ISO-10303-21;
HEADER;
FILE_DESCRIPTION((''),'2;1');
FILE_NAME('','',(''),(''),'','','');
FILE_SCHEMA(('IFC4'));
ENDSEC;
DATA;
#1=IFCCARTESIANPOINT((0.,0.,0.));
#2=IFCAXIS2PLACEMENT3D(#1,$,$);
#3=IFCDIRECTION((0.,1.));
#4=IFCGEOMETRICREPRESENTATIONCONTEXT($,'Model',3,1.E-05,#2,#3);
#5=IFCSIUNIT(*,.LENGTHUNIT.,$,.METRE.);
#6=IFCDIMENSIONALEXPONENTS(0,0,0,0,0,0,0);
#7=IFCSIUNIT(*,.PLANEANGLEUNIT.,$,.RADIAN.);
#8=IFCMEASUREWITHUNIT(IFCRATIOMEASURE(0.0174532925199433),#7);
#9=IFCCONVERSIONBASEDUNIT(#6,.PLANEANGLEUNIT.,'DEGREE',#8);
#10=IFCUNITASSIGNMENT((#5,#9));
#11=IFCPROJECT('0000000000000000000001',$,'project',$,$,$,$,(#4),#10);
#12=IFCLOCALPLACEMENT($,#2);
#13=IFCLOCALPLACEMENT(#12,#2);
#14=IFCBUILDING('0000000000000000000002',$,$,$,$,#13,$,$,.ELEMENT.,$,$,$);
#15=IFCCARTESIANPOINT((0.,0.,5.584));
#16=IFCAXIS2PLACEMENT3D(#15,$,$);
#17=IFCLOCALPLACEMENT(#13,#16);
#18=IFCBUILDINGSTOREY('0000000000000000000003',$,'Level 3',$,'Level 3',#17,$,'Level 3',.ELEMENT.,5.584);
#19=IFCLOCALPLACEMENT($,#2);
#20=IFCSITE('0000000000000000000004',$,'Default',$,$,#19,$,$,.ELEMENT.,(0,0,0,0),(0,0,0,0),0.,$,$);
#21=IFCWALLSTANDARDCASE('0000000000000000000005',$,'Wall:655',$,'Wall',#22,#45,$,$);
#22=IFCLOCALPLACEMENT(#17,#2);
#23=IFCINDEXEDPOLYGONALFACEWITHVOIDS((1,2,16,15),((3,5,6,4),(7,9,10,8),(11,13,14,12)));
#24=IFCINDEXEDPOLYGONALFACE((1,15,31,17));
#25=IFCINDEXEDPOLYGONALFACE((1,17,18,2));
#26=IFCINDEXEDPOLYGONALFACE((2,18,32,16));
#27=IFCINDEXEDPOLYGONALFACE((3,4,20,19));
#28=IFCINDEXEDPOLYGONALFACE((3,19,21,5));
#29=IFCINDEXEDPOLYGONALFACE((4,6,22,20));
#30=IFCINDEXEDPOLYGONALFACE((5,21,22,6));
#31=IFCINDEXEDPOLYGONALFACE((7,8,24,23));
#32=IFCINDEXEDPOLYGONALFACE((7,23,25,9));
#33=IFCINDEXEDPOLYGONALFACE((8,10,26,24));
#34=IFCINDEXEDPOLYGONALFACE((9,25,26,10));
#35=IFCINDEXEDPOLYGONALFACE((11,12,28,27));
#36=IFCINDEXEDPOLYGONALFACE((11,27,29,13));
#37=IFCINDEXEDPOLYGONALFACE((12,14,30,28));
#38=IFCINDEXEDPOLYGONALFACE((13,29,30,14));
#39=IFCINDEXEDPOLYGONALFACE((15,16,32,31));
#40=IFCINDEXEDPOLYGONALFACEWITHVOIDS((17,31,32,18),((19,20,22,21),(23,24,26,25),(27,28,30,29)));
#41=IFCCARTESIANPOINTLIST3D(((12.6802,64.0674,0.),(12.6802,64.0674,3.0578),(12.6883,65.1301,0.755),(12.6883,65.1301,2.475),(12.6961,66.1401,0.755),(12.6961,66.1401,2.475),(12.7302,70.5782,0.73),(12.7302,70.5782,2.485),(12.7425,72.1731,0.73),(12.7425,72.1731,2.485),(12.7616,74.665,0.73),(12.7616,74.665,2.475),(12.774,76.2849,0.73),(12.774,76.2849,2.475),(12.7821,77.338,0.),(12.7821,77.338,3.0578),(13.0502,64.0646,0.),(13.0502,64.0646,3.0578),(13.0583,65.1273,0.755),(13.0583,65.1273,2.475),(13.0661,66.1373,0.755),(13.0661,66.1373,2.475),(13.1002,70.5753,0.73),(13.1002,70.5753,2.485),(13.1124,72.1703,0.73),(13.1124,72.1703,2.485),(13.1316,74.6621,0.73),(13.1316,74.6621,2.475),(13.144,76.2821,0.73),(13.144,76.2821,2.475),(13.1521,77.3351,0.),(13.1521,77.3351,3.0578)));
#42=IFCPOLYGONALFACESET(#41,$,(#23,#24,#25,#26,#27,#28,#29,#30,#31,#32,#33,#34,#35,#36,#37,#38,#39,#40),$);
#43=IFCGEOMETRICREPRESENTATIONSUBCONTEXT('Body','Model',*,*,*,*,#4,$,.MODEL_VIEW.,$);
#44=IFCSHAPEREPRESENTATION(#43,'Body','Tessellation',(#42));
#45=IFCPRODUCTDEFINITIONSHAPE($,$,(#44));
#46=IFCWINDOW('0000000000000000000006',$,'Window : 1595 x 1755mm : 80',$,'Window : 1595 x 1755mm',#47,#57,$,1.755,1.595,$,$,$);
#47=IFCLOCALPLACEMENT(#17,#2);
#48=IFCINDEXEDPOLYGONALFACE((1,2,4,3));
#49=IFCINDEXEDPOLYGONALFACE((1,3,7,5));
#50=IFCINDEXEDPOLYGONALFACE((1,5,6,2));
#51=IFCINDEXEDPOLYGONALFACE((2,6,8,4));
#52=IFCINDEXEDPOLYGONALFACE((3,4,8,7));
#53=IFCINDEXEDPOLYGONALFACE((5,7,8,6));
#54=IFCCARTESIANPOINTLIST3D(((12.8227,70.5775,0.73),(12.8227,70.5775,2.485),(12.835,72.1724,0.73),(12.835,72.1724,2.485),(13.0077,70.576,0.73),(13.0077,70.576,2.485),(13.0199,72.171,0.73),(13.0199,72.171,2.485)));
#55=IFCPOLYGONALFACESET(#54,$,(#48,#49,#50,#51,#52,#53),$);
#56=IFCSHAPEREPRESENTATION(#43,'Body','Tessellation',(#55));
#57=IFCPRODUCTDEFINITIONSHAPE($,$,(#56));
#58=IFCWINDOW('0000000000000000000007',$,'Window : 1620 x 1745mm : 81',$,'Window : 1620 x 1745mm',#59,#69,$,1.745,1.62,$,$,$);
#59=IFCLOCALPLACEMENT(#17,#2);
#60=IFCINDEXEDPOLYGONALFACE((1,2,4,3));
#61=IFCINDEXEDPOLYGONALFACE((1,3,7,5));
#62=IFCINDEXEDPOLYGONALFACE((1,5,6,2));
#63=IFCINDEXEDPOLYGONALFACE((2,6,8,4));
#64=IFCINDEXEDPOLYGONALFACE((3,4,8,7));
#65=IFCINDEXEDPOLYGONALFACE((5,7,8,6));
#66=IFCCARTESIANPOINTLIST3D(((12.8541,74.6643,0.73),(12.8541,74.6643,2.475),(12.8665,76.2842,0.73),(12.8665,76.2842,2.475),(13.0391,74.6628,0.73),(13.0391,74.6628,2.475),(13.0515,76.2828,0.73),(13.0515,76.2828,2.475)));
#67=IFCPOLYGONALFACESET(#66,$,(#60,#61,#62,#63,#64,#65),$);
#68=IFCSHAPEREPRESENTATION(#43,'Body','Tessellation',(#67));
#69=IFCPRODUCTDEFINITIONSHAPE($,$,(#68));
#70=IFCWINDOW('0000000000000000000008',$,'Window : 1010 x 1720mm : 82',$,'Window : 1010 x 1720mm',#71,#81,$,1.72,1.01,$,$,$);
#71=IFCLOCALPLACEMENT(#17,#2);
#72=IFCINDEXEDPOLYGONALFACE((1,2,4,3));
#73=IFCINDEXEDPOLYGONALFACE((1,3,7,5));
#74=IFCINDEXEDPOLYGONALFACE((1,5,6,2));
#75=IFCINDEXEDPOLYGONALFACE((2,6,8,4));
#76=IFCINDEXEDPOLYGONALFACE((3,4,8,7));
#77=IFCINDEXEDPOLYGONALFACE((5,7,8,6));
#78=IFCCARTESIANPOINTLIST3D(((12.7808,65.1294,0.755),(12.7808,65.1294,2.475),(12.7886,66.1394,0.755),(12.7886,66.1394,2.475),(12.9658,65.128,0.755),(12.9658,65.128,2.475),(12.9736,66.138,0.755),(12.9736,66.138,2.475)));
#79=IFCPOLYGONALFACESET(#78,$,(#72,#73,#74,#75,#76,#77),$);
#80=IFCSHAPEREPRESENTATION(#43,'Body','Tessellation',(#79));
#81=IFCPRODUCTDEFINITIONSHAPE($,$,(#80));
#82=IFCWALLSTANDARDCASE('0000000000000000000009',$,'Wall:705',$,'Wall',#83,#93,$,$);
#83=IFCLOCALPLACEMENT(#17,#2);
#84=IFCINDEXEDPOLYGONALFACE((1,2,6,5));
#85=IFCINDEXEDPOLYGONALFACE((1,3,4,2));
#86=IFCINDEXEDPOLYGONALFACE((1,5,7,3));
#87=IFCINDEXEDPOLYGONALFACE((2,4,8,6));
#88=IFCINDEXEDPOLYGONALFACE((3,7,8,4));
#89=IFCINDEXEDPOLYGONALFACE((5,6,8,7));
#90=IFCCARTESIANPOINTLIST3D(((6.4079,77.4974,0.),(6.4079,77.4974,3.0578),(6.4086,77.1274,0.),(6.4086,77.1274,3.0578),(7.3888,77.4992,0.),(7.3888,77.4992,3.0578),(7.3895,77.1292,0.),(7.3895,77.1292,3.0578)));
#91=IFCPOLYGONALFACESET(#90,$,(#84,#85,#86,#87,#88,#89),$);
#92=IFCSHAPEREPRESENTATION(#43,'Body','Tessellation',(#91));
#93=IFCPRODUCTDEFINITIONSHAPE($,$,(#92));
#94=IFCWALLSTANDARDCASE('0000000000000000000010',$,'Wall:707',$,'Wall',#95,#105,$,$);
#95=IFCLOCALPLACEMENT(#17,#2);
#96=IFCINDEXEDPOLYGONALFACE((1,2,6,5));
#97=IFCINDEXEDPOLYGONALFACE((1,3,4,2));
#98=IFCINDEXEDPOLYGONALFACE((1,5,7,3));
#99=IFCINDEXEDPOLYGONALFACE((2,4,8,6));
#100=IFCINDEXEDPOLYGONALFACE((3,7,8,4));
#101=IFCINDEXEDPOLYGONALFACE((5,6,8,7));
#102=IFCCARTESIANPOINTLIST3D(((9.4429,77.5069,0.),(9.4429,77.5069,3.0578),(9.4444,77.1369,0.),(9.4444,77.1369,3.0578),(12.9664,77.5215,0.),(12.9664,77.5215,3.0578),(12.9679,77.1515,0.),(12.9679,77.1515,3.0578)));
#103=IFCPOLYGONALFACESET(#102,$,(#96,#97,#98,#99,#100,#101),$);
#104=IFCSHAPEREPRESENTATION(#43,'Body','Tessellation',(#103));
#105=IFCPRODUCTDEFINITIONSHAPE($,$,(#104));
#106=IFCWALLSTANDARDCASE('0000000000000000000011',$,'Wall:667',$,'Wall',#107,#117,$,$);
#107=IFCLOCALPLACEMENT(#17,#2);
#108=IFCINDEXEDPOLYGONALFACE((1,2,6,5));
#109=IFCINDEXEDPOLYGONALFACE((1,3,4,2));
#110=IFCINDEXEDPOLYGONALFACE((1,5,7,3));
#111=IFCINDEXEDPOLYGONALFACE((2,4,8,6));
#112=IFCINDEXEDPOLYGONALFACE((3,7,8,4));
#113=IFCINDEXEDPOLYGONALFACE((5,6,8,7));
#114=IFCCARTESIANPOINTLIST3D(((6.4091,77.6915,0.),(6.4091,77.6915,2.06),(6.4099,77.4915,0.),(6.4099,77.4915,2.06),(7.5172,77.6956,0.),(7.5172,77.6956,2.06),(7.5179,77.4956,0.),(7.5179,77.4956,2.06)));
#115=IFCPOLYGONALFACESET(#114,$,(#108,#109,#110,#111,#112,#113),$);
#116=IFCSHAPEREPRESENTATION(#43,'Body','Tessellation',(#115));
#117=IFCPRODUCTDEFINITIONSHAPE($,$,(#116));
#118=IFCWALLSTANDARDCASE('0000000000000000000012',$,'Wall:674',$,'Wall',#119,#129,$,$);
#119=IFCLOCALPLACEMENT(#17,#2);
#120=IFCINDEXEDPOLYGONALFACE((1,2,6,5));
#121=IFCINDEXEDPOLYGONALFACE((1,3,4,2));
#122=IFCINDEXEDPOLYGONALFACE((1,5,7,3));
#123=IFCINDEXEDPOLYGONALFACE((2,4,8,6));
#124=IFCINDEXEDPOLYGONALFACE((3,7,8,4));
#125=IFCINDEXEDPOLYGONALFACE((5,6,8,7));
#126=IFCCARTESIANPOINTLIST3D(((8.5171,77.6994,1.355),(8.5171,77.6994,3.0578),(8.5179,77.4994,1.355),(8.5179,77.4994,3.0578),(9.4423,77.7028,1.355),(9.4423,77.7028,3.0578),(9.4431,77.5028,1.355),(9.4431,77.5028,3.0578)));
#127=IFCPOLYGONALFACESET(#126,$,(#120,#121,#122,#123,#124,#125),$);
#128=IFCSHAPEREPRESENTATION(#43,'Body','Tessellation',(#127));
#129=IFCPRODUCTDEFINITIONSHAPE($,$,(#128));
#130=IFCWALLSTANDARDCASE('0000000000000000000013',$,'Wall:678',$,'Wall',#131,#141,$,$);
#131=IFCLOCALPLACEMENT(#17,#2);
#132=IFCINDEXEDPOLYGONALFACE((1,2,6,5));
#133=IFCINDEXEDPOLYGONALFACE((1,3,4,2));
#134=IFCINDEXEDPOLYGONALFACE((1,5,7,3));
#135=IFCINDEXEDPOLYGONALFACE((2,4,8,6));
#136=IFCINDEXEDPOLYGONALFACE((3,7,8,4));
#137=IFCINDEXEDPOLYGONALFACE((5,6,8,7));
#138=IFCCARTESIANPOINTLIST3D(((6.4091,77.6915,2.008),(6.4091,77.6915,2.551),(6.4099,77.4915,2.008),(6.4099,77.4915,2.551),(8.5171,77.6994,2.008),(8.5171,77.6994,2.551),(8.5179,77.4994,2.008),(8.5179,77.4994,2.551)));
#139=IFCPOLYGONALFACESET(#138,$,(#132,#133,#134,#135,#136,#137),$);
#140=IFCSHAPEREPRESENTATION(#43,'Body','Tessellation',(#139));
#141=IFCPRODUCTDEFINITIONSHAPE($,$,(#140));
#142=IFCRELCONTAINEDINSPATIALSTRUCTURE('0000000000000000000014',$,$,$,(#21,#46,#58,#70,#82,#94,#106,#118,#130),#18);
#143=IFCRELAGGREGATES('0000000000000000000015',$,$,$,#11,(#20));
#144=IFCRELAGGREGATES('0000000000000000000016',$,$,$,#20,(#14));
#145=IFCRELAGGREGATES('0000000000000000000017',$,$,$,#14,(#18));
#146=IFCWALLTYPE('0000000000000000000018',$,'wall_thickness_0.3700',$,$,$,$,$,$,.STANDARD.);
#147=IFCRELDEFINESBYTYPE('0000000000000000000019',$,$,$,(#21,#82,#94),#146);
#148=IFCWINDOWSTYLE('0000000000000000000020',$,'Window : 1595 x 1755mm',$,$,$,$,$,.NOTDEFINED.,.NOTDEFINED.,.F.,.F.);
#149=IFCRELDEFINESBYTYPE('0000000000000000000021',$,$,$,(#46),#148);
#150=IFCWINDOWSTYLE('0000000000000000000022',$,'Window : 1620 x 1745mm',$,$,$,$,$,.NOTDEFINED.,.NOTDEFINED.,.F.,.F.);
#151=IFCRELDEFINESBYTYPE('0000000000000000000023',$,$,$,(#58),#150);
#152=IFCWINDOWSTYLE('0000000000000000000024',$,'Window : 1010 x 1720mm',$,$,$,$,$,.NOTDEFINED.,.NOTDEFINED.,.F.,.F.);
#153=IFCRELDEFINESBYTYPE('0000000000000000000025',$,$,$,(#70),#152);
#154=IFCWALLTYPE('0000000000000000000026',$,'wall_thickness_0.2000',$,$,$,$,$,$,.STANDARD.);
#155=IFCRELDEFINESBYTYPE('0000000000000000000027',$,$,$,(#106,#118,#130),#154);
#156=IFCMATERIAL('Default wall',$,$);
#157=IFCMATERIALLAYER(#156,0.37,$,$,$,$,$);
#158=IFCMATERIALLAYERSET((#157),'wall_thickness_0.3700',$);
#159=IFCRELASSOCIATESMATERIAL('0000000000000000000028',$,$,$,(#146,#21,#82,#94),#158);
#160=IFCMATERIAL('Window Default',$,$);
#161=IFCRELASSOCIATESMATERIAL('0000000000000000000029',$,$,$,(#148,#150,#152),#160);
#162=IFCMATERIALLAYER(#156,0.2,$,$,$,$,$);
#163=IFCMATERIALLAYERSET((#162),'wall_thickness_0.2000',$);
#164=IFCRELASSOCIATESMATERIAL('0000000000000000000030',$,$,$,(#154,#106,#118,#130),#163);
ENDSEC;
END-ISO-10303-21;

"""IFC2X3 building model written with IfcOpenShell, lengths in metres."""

from ifc_helpers import new_model, entity, si_unit, converted_unit, direction, frame, frame_2d, origin, origin_2d_with_axis, place, context, subcontext, project, spatial, polyline, rectangle, outline, extrude, source, transform, mapped, material, layer, layer_set, layer_usage, type_object, type_shapes, element, fill, save


model = new_model("IFC2X3")

# Units and contexts
model_context = context("Model", 3, precision=1e-05, world=origin(), true_north=direction((0.0, 1.0)))
body_context = subcontext(model_context, "Body", "Model", "MODEL_VIEW")
ifc_project = project(units=[si_unit("LENGTHUNIT", "METRE"), converted_unit("PLANEANGLEUNIT", "DEGREE", entity("IfcRatioMeasure", 0.0174532925199433), si_unit("PLANEANGLEUNIT", "RADIAN"), dimensions=[0, 0, 0, 0, 0, 0, 0])], contexts=[model_context])

# Site, building, storey
site_placement = place(None, origin())
site = spatial("IfcSite", under=ifc_project, at=site_placement, Name="Default", CompositionType="ELEMENT", RefLatitude=(0, 0, 0, 0), RefLongitude=(0, 0, 0, 0), RefElevation=0.0)
placement_1 = place(None, origin())
building_placement = place(placement_1, origin())
building = spatial("IfcBuilding", under=site, at=building_placement, CompositionType="ELEMENT")
storey_placement = place(building_placement, frame((0.0, 0.0, 5.584)))
storey = spatial("IfcBuildingStorey", under=building, at=storey_placement, Name="Level 3", ObjectType="Level 3", LongName="Level 3", CompositionType="ELEMENT", Elevation=5.584)

# Wall, openings, windows
ifc_material_1 = material(Name="Default wall")
ifc_layer_1 = layer(ifc_material_1, 0.37)
ifc_layer_set_1 = layer_set([ifc_layer_1], Name="wall_thickness_0.3700")
ifc_layer_usage_1 = layer_usage(ifc_layer_set_1, "AXIS2", "POSITIVE", -0.185)
wall_type_1 = type_object("IfcWallType", Name="wall_thickness_0.3700", PredefinedType="STANDARD", material=ifc_layer_set_1)
wall_1_placement = place(storey_placement, frame((12.9671, 77.3365, 0.0), z_axis=(0.0, 0.0, 1.0), x_axis=(-0.007684, -0.99997, 0.0)))
wall_1 = element("IfcWallStandardCase", 1, at=wall_1_placement, inside=storey, type_object=wall_type_1, material=ifc_layer_usage_1, Name="Wall:655", ObjectType="Wall", context=body_context, shape_type="SweptSolid", body=[
    extrude(outline(polyline([(13.2709, -0.185), (13.2709, 0.185), (0.0, 0.185), (0.0, -0.185), (13.2709, -0.185)])), origin(), (0.0, 0.0, 1.0), 3.0578),
])
opening_1_placement = place(wall_1_placement, frame((5.165, -0.185, 0.73)))
opening_1 = element("IfcOpeningElement", 2, at=opening_1_placement, cuts=wall_1, ObjectType="Opening", context=body_context, shape_type="SweptSolid", body=[
    extrude(rectangle(XDim=1.595, YDim=1.755, at=frame_2d((0.8775, 0.7975), x_axis=(0.0, 1.0))), frame((0.0, 0.0, 0.0), z_axis=(0.0, 1.0, 0.0), x_axis=(0.0, 0.0, 1.0)), (0.0, 0.0, 1.0), 0.37),
])
opening_2_placement = place(wall_1_placement, frame((1.0531, -0.185, 0.73)))
opening_2 = element("IfcOpeningElement", 3, at=opening_2_placement, cuts=wall_1, ObjectType="Opening", context=body_context, shape_type="SweptSolid", body=[
    extrude(rectangle(XDim=1.62, YDim=1.745, at=frame_2d((0.8725, 0.81), x_axis=(0.0, 1.0))), frame((0.0, 0.0, 0.0), z_axis=(0.0, 1.0, 0.0), x_axis=(0.0, 0.0, 1.0)), (0.0, 0.0, 1.0), 0.37),
])
opening_3_placement = place(wall_1_placement, frame((11.1982, -0.185, 0.755)))
opening_3 = element("IfcOpeningElement", 4, at=opening_3_placement, cuts=wall_1, ObjectType="Opening", context=body_context, shape_type="SweptSolid", body=[
    extrude(rectangle(XDim=1.01, YDim=1.72, at=frame_2d((0.86, 0.505), x_axis=(0.0, 1.0))), frame((0.0, 0.0, 0.0), z_axis=(0.0, 1.0, 0.0), x_axis=(0.0, 0.0, 1.0)), (0.0, 0.0, 1.0), 0.37),
])
ifc_material_2 = material(Name="Window Default")
window_style_1 = type_object("IfcWindowStyle", Name="Window : 1595 x 1755mm", ConstructionType="NOTDEFINED", OperationType="NOTDEFINED", ParameterTakesPrecedence=False, Sizeable=False, material=ifc_material_2)
shared_shape_1 = source(origin(), body_context, "Body", "SweptSolid", [
    extrude(rectangle(XDim=0.185, YDim=1.595, at=origin_2d_with_axis()), frame((0.7975, 0.185, 0.0), z_axis=(0.0, 0.0, 1.0), x_axis=(0.0, 1.0, 0.0)), (0.0, 0.0, 1.0), 1.755),
])
type_shapes(window_style_1, [shared_shape_1])
window_1_placement = place(opening_1_placement, origin())
window_1 = element("IfcWindow", 5, at=window_1_placement, inside=storey, type_object=window_style_1, Name="Window : 1595 x 1755mm : 80", ObjectType="Window : 1595 x 1755mm", OverallHeight=1.755, OverallWidth=1.595, context=body_context, shape_type="MappedRepresentation", body=[
    mapped(shared_shape_1, transform((0.0, 0.0, 0.0), scale=1.0)),
])
fill(opening_1, window_1)
window_style_2 = type_object("IfcWindowStyle", Name="Window : 1620 x 1745mm", ConstructionType="NOTDEFINED", OperationType="NOTDEFINED", ParameterTakesPrecedence=False, Sizeable=False, material=ifc_material_2)
shared_shape_2 = source(origin(), body_context, "Body", "SweptSolid", [
    extrude(rectangle(XDim=0.185, YDim=1.62, at=origin_2d_with_axis()), frame((0.81, 0.185, 0.0), z_axis=(0.0, 0.0, 1.0), x_axis=(0.0, 1.0, 0.0)), (0.0, 0.0, 1.0), 1.745),
])
type_shapes(window_style_2, [shared_shape_2])
window_2_placement = place(opening_2_placement, origin())
window_2 = element("IfcWindow", 6, at=window_2_placement, inside=storey, type_object=window_style_2, Name="Window : 1620 x 1745mm : 81", ObjectType="Window : 1620 x 1745mm", OverallHeight=1.745, OverallWidth=1.62, context=body_context, shape_type="MappedRepresentation", body=[
    mapped(shared_shape_2, transform((0.0, 0.0, 0.0), scale=1.0)),
])
fill(opening_2, window_2)
window_style_3 = type_object("IfcWindowStyle", Name="Window : 1010 x 1720mm", ConstructionType="NOTDEFINED", OperationType="NOTDEFINED", ParameterTakesPrecedence=False, Sizeable=False, material=ifc_material_2)
shared_shape_3 = source(origin(), body_context, "Body", "SweptSolid", [
    extrude(rectangle(XDim=0.185, YDim=1.01, at=origin_2d_with_axis()), frame((0.505, 0.185, 0.0), z_axis=(0.0, 0.0, 1.0), x_axis=(0.0, 1.0, 0.0)), (0.0, 0.0, 1.0), 1.72),
])
type_shapes(window_style_3, [shared_shape_3])
window_3_placement = place(opening_3_placement, origin())
window_3 = element("IfcWindow", 7, at=window_3_placement, inside=storey, type_object=window_style_3, Name="Window : 1010 x 1720mm : 82", ObjectType="Window : 1010 x 1720mm", OverallHeight=1.72, OverallWidth=1.01, context=body_context, shape_type="MappedRepresentation", body=[
    mapped(shared_shape_3, transform((0.0, 0.0, 0.0), scale=1.0)),
])
fill(opening_3, window_3)

# Walls
wall_2_placement = place(storey_placement, frame((7.3891, 77.3142, 0.0), z_axis=(0.0, 0.0, 1.0), x_axis=(-0.999998, -0.001843, 0.0)))
element("IfcWallStandardCase", 8, at=wall_2_placement, inside=storey, type_object=wall_type_1, material=ifc_layer_usage_1, Name="Wall:705", ObjectType="Wall", context=body_context, shape_type="SweptSolid", body=[
    extrude(outline(polyline([(0.9809, -0.185), (0.9809, 0.185), (0.0, 0.185), (0.0, -0.185), (0.9809, -0.185)])), origin(), (0.0, 0.0, 1.0), 3.0578),
])
wall_3_placement = place(storey_placement, frame((9.4436, 77.3219, 0.0), z_axis=(0.0, 0.0, 1.0), x_axis=(0.999991, 0.004149, 0.0)))
element("IfcWallStandardCase", 9, at=wall_3_placement, inside=storey, type_object=wall_type_1, material=ifc_layer_usage_1, Name="Wall:707", ObjectType="Wall", context=body_context, shape_type="SweptSolid", body=[
    extrude(outline(polyline([(3.5235, -0.185), (3.5235, 0.185), (0.0, 0.185), (0.0, -0.185), (3.5235, -0.185)])), origin(), (0.0, 0.0, 1.0), 3.0578),
])
ifc_layer_2 = layer(ifc_material_1, 0.2)
ifc_layer_set_2 = layer_set([ifc_layer_2], Name="wall_thickness_0.2000")
ifc_layer_usage_2 = layer_usage(ifc_layer_set_2, "AXIS2", "POSITIVE", -0.1)
wall_type_2 = type_object("IfcWallType", Name="wall_thickness_0.2000", PredefinedType="STANDARD", material=ifc_layer_set_2)
wall_4_placement = place(storey_placement, frame((6.4095, 77.5915, 0.0), z_axis=(0.0, 0.0, 1.0), x_axis=(0.999993, 0.003732, 0.0)))
element("IfcWallStandardCase", 10, at=wall_4_placement, inside=storey, type_object=wall_type_2, material=ifc_layer_usage_2, Name="Wall:667", ObjectType="Wall", context=body_context, shape_type="SweptSolid", body=[
    extrude(outline(polyline([(1.108, -0.1), (1.108, 0.1), (0.0, 0.1), (0.0, -0.1), (1.108, -0.1)])), origin(), (0.0, 0.0, 1.0), 2.06),
])
placement_2 = place(building_placement, frame((0.0, 0.0, 6.939)))
wall_5_placement = place(placement_2, frame((8.5175, 77.5994, 0.0), z_axis=(0.0, 0.0, 1.0), x_axis=(0.999993, 0.003744, 0.0)))
element("IfcWallStandardCase", 11, at=wall_5_placement, inside=storey, type_object=wall_type_2, material=ifc_layer_usage_2, Name="Wall:674", ObjectType="Wall", context=body_context, shape_type="SweptSolid", body=[
    extrude(outline(polyline([(0.9252, -0.1), (0.9252, 0.1), (0.0, 0.1), (0.0, -0.1), (0.9252, -0.1)])), origin(), (0.0, 0.0, 1.0), 1.7028),
])
placement_3 = place(building_placement, frame((0.0, 0.0, 7.592)))
wall_6_placement = place(placement_3, frame((6.4095, 77.5915, 0.0), z_axis=(0.0, 0.0, 1.0), x_axis=(0.999993, 0.003731, 0.0)))
element("IfcWallStandardCase", 12, at=wall_6_placement, inside=storey, type_object=wall_type_2, material=ifc_layer_usage_2, Name="Wall:678", ObjectType="Wall", context=body_context, shape_type="SweptSolid", body=[
    extrude(outline(polyline([(2.108, -0.1), (2.108, 0.1), (0.0, 0.1), (0.0, -0.1), (2.108, -0.1)])), origin(), (0.0, 0.0, 1.0), 0.543),
])

save(model, "model.ifc")
